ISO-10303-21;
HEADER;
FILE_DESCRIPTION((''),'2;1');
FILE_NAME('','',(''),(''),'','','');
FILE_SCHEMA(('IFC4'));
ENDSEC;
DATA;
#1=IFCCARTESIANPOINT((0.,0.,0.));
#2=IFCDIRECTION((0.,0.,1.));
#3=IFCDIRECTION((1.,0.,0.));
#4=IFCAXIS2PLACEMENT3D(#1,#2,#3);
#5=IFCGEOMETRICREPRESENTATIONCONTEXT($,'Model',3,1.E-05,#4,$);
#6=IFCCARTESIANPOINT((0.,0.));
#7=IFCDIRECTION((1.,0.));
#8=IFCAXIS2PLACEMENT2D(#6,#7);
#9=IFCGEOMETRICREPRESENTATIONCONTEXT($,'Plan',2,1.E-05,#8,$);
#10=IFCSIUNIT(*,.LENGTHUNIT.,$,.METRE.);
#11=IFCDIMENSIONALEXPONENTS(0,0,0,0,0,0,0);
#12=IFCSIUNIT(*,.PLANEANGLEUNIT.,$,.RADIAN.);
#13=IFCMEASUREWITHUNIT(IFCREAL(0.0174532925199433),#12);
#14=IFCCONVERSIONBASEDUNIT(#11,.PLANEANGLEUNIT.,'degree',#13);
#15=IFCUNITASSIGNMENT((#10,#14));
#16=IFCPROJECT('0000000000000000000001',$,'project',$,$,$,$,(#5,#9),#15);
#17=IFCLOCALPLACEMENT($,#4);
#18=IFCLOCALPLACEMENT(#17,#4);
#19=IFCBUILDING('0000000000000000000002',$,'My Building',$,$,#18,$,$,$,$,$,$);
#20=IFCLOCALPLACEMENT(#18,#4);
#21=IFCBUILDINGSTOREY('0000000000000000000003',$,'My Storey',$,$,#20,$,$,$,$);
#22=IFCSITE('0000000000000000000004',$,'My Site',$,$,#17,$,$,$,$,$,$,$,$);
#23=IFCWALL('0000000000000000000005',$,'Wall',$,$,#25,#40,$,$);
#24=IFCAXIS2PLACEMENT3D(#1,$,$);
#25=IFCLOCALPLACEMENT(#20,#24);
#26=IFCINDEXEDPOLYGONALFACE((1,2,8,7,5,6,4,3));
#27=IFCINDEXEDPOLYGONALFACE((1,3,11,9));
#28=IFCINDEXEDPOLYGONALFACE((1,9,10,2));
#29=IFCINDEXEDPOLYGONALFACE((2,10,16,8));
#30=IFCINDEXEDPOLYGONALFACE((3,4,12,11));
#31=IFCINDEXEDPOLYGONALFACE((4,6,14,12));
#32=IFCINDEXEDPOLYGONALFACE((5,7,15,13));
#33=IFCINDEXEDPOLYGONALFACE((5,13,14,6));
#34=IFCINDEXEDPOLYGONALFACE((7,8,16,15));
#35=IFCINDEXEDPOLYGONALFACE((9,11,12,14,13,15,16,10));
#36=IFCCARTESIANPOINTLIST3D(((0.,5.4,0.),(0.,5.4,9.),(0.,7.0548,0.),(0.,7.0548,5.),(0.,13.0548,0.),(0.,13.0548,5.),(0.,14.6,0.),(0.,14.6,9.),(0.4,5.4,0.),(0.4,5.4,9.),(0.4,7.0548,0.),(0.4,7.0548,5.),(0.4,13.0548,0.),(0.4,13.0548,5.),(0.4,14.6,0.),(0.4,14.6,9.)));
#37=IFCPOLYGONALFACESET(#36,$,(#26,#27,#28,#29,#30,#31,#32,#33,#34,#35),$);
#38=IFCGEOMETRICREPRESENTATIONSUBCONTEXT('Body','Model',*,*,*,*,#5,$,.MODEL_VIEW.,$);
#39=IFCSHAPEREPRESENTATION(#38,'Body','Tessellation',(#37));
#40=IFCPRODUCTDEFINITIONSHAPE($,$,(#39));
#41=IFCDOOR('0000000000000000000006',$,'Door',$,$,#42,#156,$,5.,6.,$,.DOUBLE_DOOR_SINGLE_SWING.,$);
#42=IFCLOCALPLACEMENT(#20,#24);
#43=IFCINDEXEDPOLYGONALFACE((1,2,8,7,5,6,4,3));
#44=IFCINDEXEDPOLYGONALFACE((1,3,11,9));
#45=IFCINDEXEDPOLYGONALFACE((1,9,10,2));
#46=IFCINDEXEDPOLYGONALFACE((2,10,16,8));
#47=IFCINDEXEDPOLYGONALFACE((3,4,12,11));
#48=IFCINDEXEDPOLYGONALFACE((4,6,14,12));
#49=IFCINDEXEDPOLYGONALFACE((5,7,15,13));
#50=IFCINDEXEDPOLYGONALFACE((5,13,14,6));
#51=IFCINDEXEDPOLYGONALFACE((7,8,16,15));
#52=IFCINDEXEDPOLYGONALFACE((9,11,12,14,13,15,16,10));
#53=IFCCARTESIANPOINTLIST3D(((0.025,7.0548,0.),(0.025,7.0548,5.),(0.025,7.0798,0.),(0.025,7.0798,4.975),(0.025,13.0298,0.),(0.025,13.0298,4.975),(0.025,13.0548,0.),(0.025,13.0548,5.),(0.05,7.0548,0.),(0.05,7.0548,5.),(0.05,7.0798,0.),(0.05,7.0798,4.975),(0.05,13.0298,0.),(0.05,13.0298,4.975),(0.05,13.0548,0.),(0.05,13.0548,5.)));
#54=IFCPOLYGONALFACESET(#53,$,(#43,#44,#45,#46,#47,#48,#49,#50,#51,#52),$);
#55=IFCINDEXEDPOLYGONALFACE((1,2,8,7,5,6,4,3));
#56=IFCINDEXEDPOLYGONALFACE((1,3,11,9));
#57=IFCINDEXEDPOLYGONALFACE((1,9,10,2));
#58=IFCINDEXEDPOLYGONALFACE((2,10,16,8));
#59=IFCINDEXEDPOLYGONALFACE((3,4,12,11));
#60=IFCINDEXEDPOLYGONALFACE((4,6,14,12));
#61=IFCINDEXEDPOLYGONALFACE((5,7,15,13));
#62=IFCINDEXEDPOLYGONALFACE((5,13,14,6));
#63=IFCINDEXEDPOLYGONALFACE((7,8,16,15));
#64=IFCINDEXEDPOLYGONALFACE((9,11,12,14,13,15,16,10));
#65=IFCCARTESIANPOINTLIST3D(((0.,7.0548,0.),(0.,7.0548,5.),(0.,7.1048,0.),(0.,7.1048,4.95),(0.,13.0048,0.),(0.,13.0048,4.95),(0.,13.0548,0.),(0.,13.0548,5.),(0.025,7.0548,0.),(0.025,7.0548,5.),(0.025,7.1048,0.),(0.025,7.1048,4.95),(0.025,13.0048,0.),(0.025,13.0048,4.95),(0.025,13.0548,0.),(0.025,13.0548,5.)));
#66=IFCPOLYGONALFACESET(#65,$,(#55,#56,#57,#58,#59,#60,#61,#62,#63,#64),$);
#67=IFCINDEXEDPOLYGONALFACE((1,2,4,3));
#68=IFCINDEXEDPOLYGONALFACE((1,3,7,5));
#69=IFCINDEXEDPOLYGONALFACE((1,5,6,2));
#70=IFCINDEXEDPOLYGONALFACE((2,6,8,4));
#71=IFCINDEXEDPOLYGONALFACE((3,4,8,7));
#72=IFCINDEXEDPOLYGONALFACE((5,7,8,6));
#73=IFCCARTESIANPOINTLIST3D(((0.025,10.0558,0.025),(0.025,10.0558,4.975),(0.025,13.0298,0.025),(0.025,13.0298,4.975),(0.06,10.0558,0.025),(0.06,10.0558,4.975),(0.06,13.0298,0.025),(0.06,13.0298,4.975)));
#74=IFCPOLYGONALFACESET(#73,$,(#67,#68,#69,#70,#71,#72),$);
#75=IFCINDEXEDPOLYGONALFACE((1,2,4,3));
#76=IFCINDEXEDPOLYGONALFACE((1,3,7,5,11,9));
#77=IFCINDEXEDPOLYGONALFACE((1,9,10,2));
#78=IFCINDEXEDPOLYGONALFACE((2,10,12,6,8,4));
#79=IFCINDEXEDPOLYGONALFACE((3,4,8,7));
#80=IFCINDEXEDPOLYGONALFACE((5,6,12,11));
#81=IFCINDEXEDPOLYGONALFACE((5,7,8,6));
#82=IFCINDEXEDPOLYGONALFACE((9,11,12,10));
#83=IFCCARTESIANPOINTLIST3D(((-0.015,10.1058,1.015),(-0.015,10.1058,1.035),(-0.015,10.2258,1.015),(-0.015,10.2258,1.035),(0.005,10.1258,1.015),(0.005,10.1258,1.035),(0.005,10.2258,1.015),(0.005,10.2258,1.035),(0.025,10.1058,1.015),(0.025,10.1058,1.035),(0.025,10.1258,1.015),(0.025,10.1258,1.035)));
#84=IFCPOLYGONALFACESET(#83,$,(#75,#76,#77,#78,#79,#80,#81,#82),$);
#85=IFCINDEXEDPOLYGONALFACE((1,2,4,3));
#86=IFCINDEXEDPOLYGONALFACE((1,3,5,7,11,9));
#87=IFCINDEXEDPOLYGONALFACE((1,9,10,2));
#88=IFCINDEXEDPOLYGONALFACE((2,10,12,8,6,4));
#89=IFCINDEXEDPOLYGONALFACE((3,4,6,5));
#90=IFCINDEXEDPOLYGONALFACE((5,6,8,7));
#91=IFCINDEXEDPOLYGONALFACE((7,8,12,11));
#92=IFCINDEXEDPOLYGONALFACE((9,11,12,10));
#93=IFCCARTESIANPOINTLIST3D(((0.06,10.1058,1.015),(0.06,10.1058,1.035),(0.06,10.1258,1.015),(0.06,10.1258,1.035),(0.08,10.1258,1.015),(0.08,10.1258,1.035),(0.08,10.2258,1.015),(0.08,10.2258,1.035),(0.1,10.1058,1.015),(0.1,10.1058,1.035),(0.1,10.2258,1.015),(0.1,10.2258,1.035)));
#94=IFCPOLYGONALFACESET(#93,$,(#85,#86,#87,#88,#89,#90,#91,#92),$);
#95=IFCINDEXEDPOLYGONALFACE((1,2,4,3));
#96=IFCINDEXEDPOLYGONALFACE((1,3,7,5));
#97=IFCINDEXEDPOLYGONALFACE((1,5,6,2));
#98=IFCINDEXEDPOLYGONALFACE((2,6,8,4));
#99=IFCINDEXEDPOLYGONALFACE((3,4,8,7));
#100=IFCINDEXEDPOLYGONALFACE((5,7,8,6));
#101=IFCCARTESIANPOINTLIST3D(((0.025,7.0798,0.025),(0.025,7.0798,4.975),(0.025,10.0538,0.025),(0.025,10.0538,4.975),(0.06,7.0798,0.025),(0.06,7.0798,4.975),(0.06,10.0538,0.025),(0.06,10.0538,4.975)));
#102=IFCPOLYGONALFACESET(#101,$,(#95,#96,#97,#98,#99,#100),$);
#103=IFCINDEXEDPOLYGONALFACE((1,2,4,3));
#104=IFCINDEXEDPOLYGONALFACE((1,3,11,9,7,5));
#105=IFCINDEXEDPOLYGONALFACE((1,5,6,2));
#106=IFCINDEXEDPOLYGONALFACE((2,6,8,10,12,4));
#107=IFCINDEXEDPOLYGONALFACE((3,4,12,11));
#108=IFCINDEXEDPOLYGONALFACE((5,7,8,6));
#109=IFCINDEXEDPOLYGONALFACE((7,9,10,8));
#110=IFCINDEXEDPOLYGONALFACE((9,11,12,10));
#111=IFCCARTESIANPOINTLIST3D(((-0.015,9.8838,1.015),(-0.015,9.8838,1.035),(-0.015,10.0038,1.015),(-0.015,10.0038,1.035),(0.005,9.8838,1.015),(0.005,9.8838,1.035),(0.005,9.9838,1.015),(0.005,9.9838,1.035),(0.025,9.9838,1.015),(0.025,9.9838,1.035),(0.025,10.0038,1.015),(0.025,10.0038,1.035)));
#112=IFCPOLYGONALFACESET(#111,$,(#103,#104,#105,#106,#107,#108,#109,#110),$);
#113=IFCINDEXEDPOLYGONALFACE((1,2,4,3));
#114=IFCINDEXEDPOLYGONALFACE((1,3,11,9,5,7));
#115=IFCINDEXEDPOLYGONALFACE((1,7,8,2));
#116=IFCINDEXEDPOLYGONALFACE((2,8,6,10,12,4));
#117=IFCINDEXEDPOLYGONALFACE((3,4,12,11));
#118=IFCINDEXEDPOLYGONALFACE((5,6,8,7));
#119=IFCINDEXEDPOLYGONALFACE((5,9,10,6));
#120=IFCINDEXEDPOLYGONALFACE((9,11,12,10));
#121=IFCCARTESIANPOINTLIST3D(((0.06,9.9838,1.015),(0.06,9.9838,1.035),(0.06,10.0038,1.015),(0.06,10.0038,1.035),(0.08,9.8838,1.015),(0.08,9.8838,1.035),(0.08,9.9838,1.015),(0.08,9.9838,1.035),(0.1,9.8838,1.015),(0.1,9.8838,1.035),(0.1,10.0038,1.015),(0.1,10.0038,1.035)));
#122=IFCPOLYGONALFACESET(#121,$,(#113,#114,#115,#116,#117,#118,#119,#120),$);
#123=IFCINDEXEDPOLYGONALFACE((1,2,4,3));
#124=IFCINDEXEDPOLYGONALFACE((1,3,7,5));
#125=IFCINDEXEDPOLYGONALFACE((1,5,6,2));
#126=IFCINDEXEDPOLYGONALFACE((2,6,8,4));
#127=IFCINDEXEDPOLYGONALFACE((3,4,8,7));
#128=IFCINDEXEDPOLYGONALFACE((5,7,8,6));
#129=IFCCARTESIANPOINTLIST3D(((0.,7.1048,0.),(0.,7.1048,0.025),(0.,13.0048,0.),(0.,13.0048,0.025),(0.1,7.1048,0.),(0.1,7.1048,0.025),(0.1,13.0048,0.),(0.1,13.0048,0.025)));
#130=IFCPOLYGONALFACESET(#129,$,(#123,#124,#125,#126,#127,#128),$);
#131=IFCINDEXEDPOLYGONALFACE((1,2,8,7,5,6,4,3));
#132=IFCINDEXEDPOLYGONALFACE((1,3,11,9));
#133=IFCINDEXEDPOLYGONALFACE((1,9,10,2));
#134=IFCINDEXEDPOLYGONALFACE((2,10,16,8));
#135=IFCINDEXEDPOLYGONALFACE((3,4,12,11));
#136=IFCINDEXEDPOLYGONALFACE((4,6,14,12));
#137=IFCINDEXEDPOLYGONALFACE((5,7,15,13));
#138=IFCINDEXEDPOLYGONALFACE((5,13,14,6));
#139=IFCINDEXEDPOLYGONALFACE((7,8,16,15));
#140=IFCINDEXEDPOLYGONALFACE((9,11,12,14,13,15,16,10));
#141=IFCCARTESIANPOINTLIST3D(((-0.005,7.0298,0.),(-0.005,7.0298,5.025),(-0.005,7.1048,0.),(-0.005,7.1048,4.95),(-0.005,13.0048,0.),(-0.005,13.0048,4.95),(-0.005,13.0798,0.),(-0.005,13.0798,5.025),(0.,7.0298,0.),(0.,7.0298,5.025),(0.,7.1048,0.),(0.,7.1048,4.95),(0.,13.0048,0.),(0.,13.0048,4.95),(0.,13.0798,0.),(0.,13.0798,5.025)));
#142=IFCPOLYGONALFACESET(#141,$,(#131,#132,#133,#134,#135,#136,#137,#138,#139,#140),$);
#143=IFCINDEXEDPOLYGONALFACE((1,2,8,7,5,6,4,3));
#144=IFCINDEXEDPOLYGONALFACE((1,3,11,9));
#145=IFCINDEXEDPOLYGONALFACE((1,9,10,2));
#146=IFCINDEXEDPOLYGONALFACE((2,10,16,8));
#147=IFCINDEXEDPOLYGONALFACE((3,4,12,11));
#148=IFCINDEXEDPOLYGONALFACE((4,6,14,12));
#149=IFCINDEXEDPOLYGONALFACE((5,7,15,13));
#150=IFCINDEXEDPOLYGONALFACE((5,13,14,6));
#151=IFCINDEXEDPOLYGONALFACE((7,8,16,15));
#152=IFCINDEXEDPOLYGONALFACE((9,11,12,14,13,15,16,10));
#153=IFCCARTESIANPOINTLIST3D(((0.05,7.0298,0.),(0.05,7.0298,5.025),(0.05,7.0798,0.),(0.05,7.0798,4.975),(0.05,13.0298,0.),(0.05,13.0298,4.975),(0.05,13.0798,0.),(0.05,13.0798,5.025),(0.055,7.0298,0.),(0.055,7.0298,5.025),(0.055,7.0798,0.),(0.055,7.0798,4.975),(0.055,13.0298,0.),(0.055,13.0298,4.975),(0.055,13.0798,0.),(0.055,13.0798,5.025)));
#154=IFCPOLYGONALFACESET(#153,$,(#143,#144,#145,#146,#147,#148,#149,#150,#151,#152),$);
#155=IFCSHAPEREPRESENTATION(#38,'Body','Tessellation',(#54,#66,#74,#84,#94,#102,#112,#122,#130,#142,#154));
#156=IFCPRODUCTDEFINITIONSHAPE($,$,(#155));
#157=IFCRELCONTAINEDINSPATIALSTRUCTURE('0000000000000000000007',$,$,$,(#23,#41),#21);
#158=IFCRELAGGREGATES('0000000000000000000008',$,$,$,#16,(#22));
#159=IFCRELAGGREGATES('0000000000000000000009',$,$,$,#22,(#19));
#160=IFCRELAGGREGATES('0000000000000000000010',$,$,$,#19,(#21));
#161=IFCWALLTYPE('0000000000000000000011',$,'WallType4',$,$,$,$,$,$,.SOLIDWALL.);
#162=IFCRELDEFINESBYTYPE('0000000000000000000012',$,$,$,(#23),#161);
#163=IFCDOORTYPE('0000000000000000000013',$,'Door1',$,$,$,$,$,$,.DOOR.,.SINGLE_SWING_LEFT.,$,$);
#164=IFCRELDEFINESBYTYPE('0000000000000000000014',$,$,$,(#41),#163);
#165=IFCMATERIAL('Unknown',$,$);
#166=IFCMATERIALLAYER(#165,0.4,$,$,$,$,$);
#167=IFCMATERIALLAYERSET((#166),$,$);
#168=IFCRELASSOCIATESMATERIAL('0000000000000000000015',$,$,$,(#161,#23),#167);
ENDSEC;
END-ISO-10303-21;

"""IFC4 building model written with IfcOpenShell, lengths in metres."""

from ifc_helpers import new_model, entity, si_unit, converted_unit, frame, origin_with_axes, origin_2d_with_axis, place, context, subcontext, project, spatial, line, indexed_curve, outline, extrude, shape, source, transform, mapped, material, layer, layer_set, layer_usage, type_object, type_shapes, element, fill, save


model = new_model("IFC4")

# Units and contexts
model_context = context("Model", 3, precision=1e-05, world=origin_with_axes())
plan_context = context("Plan", 2, precision=1e-05, world=origin_2d_with_axis())
body_context_1 = subcontext(model_context, "Body", "Model", "MODEL_VIEW")
body_context_2 = subcontext(plan_context, "Body", "Plan", "PLAN_VIEW")
ifc_project = project(units=[si_unit("LENGTHUNIT", "METRE"), converted_unit("PLANEANGLEUNIT", "degree", entity("IfcReal", 0.0174532925199433), si_unit("PLANEANGLEUNIT", "RADIAN"), dimensions=[0, 0, 0, 0, 0, 0, 0])], contexts=[model_context, plan_context])

# Site, building, storey
site_placement = place(None, origin_with_axes())
site = spatial("IfcSite", under=ifc_project, at=site_placement, Name="My Site")
building_placement = place(site_placement, origin_with_axes())
building = spatial("IfcBuilding", under=site, at=building_placement, Name="My Building")
storey_placement = place(building_placement, origin_with_axes())
storey = spatial("IfcBuildingStorey", under=building, at=storey_placement, Name="My Storey")

# Shared definitions
ifc_material = material(Name="Unknown")
ifc_layer = layer(ifc_material, 0.4)
ifc_layer_set = layer_set([ifc_layer])
wall_type = type_object("IfcWallType", Name="WallType4", PredefinedType="SOLIDWALL", material=ifc_layer_set)

# Wall, opening, door
ifc_layer_usage_1 = layer_usage(ifc_layer_set, "AXIS2", "POSITIVE", 0.0)
wall_1_placement = place(storey_placement, frame((0.0, 14.6, 0.0), z_axis=(0.0, 0.0, 1.0), x_axis=(0.0, -1.0, 0.0)))
wall_1 = element("IfcWall", 1, at=wall_1_placement, inside=storey, type_object=wall_type, material=ifc_layer_usage_1, Name="Wall", context=body_context_1, shape_type="SweptSolid", body=[
    extrude(outline(indexed_curve([(0.0, 0.0), (0.0, 0.4), (9.2, 0.4), (9.2, 0.0), (0.0, 0.0)], self_intersect=False)), origin_with_axes(), (0.0, 0.0, 1.0), 9.0),
])
shared_shape_1 = source(origin_with_axes(), body_context_1, "Body", "SweptSolid", [
    extrude(outline(indexed_curve([(0.0, 0.0), (6.0, 0.0), (6.0, 5.0), (0.0, 5.0)], segments=[line(1, 2, 3, 4, 1)])), frame((0.0, -0.1, 0.0), z_axis=(0.0, -1.0, 0.0), x_axis=(1.0, 0.0, 0.0)), (0.0, 0.0, -1.0), 0.6),
])
opening_1_placement = place(wall_1_placement, frame((1.5452, 0.0, 0.0), z_axis=(0.0, 0.0, 1.0), x_axis=(1.0, 0.0, 0.0)))
opening_1 = element("IfcOpeningElement", 2, at=opening_1_placement, cuts=wall_1, PredefinedType="OPENING", context=body_context_1, shape_type="MappedRepresentation", body=[
    mapped(shared_shape_1, transform((0.0, 0.0, 0.0), x_axis=(1.0, 0.0, 0.0), y_axis=(0.0, 1.0, 0.0), z_axis=(0.0, 0.0, 1.0), scale=1.0)),
])
door_type = type_object("IfcDoorType", Name="Door1", OperationType="SINGLE_SWING_LEFT", PredefinedType="DOOR")
shared_shape_2 = source(origin_with_axes(), body_context_1, "Body", "SweptSolid", [
    extrude(outline(indexed_curve([(0.0, 0.0), (0.0, 5.0), (6.0, 5.0), (6.0, 0.0), (5.975, 0.0), (5.975, 4.975), (0.025, 4.975), (0.025, 0.0)], segments=[line(1, 2, 3, 4, 5, 6, 7, 8, 1)])), frame((0.0, 0.025, 0.0), z_axis=(0.0, -1.0, 0.0), x_axis=(1.0, 0.0, 0.0)), (0.0, 0.0, -1.0), 0.025),
    extrude(outline(indexed_curve([(0.0, 0.0), (0.0, 5.0), (6.0, 5.0), (6.0, 0.0), (5.95, 0.0), (5.95, 4.95), (0.05, 4.95), (0.05, 0.0)], segments=[line(1, 2, 3, 4, 5, 6, 7, 8, 1)])), frame((0.0, 0.0, 0.0), z_axis=(0.0, -1.0, 0.0), x_axis=(1.0, 0.0, 0.0)), (0.0, 0.0, -1.0), 0.025),
    extrude(outline(indexed_curve([(0.0, 0.0), (2.974, 0.0), (2.974, 0.035), (0.0, 0.035)], segments=[line(1, 2, 3, 4, 1)])), frame((0.025, 0.025, 0.025), z_axis=(0.0, 0.0, 1.0), x_axis=(1.0, 0.0, 0.0)), (0.0, 0.0, 1.0), 4.95),
    extrude(outline(indexed_curve([(0.0, 0.0), (0.0, -0.04), (-0.12, -0.04), (-0.12, -0.02), (-0.02, -0.02), (-0.02, 0.0)], segments=[line(1, 2, 3, 4, 5, 6, 1)])), frame((2.949, 0.025, 1.015), z_axis=(0.0, 0.0, 1.0), x_axis=(1.0, 0.0, 0.0)), (0.0, 0.0, 1.0), 0.02),
    extrude(outline(indexed_curve([(0.0, 0.0), (0.0, 0.04), (-0.12, 0.04), (-0.12, 0.02), (-0.02, 0.02), (-0.02, 0.0)], segments=[line(1, 2, 3, 4, 5, 6, 1)])), frame((2.949, 0.06, 1.015), z_axis=(0.0, 0.0, 1.0), x_axis=(1.0, 0.0, 0.0)), (0.0, 0.0, 1.0), 0.02),
    extrude(outline(indexed_curve([(0.0, 0.0), (-2.974, 0.0), (-2.974, 0.035), (0.0, 0.035)], segments=[line(1, 2, 3, 4, 1)])), frame((5.975, 0.025, 0.025), z_axis=(0.0, 0.0, 1.0), x_axis=(1.0, 0.0, 0.0)), (0.0, 0.0, 1.0), 4.95),
    extrude(outline(indexed_curve([(0.0, 0.0), (0.0, -0.04), (0.12, -0.04), (0.12, -0.02), (0.02, -0.02), (0.02, 0.0)], segments=[line(1, 2, 3, 4, 5, 6, 1)])), frame((3.051, 0.025, 1.015), z_axis=(0.0, 0.0, 1.0), x_axis=(1.0, 0.0, 0.0)), (0.0, 0.0, 1.0), 0.02),
    extrude(outline(indexed_curve([(0.0, 0.0), (0.0, 0.04), (0.12, 0.04), (0.12, 0.02), (0.02, 0.02), (0.02, 0.0)], segments=[line(1, 2, 3, 4, 5, 6, 1)])), frame((3.051, 0.06, 1.015), z_axis=(0.0, 0.0, 1.0), x_axis=(1.0, 0.0, 0.0)), (0.0, 0.0, 1.0), 0.02),
    extrude(outline(indexed_curve([(0.0, 0.0), (5.9, 0.0), (5.9, 0.1), (0.0, 0.1)], segments=[line(1, 2, 3, 4, 1)])), frame((0.05, 0.0, 0.0), z_axis=(0.0, 0.0, 1.0), x_axis=(1.0, 0.0, 0.0)), (0.0, 0.0, 1.0), 0.025),
    extrude(outline(indexed_curve([(0.0, 0.0), (0.0, 5.025), (6.05, 5.025), (6.05, 0.0), (5.975, 0.0), (5.975, 4.95), (0.075, 4.95), (0.075, 0.0)], segments=[line(1, 2, 3, 4, 5, 6, 7, 8, 1)])), frame((-0.025, -0.005, 0.0), z_axis=(0.0, -1.0, 0.0), x_axis=(1.0, 0.0, 0.0)), (0.0, 0.0, -1.0), 0.005),
    extrude(outline(indexed_curve([(0.0, 0.0), (0.0, 5.025), (6.05, 5.025), (6.05, 0.0), (6.0, 0.0), (6.0, 4.975), (0.05, 4.975), (0.05, 0.0)], segments=[line(1, 2, 3, 4, 5, 6, 7, 8, 1)])), frame((-0.025, 0.05, 0.0), z_axis=(0.0, -1.0, 0.0), x_axis=(1.0, 0.0, 0.0)), (0.0, 0.0, -1.0), 0.005),
])
shared_shape_3 = source(origin_with_axes(), body_context_2, "Body", "Curve2D", [
    entity("IfcIndexedPolyCurve", entity("IfcCartesianPointList2D", [[0.0, 0.0], [0.0, 0.05], [0.025, 0.05], [0.025, 0.025], [0.05, 0.025], [0.05, 0.0]]), [entity("IfcLineIndex", [1, 2, 3, 4, 5, 6, 1])]),
    entity("IfcIndexedPolyCurve", entity("IfcCartesianPointList2D", [[6.0, 0.0], [6.0, 0.05], [5.975, 0.05], [5.975, 0.025], [5.95, 0.025], [5.95, 0.0]]), [entity("IfcLineIndex", [1, 2, 3, 4, 5, 6, 1])]),
    entity("IfcTrimmedCurve", entity("IfcEllipse", entity("IfcAxis2Placement2D", entity("IfcCartesianPoint", [0.06, 0.05]), entity("IfcDirection", [1.0, 0.0])), 2.94, 2.975), [entity("IfcCartesianPoint", [3.0, 0.05])], [entity("IfcCartesianPoint", [0.06, 3.025])], True, "CARTESIAN"),
    entity("IfcIndexedPolyCurve", entity("IfcCartesianPointList2D", [[0.025, 0.05], [0.06, 0.05], [0.06, 3.025], [0.025, 3.025]]), [entity("IfcLineIndex", [1, 2, 3, 4, 1])]),
    entity("IfcTrimmedCurve", entity("IfcEllipse", entity("IfcAxis2Placement2D", entity("IfcCartesianPoint", [5.94, 0.05]), entity("IfcDirection", [1.0, 0.0])), 2.94, 2.975), [entity("IfcCartesianPoint", [5.94, 3.025])], [entity("IfcCartesianPoint", [3.0, 0.05])], True, "CARTESIAN"),
    entity("IfcIndexedPolyCurve", entity("IfcCartesianPointList2D", [[5.975, 0.05], [5.94, 0.05], [5.94, 3.025], [5.975, 3.025]]), [entity("IfcLineIndex", [1, 2, 3, 4, 1])]),
])
type_shapes(door_type, [shared_shape_2, shared_shape_3])
door_1_placement = place(opening_1_placement, frame((0.0, 0.0, 0.0), z_axis=(0.0, 0.0, 1.0), x_axis=(1.0, 0.0, 0.0)))
door_1 = element("IfcDoor", 3, at=door_1_placement, inside=storey, type_object=door_type, Name="Door", OperationType="DOUBLE_DOOR_SINGLE_SWING", OverallHeight=5.0, OverallWidth=6.0, shapes=[
    shape(body_context_1, "Body", "MappedRepresentation", [mapped(shared_shape_2, transform((0.0, 0.0, 0.0), x_axis=(1.0, 0.0, 0.0), y_axis=(0.0, 1.0, 0.0), z_axis=(0.0, 0.0, 1.0), scale=1.0))]),
    shape(body_context_2, "Body", "MappedRepresentation", [mapped(shared_shape_3, transform((0.0, 0.0, 0.0), x_axis=(1.0, 0.0, 0.0), y_axis=(0.0, 1.0, 0.0), z_axis=(0.0, 0.0, 1.0), scale=1.0))]),
])
fill(opening_1, door_1)

save(model, "model.ifc")
